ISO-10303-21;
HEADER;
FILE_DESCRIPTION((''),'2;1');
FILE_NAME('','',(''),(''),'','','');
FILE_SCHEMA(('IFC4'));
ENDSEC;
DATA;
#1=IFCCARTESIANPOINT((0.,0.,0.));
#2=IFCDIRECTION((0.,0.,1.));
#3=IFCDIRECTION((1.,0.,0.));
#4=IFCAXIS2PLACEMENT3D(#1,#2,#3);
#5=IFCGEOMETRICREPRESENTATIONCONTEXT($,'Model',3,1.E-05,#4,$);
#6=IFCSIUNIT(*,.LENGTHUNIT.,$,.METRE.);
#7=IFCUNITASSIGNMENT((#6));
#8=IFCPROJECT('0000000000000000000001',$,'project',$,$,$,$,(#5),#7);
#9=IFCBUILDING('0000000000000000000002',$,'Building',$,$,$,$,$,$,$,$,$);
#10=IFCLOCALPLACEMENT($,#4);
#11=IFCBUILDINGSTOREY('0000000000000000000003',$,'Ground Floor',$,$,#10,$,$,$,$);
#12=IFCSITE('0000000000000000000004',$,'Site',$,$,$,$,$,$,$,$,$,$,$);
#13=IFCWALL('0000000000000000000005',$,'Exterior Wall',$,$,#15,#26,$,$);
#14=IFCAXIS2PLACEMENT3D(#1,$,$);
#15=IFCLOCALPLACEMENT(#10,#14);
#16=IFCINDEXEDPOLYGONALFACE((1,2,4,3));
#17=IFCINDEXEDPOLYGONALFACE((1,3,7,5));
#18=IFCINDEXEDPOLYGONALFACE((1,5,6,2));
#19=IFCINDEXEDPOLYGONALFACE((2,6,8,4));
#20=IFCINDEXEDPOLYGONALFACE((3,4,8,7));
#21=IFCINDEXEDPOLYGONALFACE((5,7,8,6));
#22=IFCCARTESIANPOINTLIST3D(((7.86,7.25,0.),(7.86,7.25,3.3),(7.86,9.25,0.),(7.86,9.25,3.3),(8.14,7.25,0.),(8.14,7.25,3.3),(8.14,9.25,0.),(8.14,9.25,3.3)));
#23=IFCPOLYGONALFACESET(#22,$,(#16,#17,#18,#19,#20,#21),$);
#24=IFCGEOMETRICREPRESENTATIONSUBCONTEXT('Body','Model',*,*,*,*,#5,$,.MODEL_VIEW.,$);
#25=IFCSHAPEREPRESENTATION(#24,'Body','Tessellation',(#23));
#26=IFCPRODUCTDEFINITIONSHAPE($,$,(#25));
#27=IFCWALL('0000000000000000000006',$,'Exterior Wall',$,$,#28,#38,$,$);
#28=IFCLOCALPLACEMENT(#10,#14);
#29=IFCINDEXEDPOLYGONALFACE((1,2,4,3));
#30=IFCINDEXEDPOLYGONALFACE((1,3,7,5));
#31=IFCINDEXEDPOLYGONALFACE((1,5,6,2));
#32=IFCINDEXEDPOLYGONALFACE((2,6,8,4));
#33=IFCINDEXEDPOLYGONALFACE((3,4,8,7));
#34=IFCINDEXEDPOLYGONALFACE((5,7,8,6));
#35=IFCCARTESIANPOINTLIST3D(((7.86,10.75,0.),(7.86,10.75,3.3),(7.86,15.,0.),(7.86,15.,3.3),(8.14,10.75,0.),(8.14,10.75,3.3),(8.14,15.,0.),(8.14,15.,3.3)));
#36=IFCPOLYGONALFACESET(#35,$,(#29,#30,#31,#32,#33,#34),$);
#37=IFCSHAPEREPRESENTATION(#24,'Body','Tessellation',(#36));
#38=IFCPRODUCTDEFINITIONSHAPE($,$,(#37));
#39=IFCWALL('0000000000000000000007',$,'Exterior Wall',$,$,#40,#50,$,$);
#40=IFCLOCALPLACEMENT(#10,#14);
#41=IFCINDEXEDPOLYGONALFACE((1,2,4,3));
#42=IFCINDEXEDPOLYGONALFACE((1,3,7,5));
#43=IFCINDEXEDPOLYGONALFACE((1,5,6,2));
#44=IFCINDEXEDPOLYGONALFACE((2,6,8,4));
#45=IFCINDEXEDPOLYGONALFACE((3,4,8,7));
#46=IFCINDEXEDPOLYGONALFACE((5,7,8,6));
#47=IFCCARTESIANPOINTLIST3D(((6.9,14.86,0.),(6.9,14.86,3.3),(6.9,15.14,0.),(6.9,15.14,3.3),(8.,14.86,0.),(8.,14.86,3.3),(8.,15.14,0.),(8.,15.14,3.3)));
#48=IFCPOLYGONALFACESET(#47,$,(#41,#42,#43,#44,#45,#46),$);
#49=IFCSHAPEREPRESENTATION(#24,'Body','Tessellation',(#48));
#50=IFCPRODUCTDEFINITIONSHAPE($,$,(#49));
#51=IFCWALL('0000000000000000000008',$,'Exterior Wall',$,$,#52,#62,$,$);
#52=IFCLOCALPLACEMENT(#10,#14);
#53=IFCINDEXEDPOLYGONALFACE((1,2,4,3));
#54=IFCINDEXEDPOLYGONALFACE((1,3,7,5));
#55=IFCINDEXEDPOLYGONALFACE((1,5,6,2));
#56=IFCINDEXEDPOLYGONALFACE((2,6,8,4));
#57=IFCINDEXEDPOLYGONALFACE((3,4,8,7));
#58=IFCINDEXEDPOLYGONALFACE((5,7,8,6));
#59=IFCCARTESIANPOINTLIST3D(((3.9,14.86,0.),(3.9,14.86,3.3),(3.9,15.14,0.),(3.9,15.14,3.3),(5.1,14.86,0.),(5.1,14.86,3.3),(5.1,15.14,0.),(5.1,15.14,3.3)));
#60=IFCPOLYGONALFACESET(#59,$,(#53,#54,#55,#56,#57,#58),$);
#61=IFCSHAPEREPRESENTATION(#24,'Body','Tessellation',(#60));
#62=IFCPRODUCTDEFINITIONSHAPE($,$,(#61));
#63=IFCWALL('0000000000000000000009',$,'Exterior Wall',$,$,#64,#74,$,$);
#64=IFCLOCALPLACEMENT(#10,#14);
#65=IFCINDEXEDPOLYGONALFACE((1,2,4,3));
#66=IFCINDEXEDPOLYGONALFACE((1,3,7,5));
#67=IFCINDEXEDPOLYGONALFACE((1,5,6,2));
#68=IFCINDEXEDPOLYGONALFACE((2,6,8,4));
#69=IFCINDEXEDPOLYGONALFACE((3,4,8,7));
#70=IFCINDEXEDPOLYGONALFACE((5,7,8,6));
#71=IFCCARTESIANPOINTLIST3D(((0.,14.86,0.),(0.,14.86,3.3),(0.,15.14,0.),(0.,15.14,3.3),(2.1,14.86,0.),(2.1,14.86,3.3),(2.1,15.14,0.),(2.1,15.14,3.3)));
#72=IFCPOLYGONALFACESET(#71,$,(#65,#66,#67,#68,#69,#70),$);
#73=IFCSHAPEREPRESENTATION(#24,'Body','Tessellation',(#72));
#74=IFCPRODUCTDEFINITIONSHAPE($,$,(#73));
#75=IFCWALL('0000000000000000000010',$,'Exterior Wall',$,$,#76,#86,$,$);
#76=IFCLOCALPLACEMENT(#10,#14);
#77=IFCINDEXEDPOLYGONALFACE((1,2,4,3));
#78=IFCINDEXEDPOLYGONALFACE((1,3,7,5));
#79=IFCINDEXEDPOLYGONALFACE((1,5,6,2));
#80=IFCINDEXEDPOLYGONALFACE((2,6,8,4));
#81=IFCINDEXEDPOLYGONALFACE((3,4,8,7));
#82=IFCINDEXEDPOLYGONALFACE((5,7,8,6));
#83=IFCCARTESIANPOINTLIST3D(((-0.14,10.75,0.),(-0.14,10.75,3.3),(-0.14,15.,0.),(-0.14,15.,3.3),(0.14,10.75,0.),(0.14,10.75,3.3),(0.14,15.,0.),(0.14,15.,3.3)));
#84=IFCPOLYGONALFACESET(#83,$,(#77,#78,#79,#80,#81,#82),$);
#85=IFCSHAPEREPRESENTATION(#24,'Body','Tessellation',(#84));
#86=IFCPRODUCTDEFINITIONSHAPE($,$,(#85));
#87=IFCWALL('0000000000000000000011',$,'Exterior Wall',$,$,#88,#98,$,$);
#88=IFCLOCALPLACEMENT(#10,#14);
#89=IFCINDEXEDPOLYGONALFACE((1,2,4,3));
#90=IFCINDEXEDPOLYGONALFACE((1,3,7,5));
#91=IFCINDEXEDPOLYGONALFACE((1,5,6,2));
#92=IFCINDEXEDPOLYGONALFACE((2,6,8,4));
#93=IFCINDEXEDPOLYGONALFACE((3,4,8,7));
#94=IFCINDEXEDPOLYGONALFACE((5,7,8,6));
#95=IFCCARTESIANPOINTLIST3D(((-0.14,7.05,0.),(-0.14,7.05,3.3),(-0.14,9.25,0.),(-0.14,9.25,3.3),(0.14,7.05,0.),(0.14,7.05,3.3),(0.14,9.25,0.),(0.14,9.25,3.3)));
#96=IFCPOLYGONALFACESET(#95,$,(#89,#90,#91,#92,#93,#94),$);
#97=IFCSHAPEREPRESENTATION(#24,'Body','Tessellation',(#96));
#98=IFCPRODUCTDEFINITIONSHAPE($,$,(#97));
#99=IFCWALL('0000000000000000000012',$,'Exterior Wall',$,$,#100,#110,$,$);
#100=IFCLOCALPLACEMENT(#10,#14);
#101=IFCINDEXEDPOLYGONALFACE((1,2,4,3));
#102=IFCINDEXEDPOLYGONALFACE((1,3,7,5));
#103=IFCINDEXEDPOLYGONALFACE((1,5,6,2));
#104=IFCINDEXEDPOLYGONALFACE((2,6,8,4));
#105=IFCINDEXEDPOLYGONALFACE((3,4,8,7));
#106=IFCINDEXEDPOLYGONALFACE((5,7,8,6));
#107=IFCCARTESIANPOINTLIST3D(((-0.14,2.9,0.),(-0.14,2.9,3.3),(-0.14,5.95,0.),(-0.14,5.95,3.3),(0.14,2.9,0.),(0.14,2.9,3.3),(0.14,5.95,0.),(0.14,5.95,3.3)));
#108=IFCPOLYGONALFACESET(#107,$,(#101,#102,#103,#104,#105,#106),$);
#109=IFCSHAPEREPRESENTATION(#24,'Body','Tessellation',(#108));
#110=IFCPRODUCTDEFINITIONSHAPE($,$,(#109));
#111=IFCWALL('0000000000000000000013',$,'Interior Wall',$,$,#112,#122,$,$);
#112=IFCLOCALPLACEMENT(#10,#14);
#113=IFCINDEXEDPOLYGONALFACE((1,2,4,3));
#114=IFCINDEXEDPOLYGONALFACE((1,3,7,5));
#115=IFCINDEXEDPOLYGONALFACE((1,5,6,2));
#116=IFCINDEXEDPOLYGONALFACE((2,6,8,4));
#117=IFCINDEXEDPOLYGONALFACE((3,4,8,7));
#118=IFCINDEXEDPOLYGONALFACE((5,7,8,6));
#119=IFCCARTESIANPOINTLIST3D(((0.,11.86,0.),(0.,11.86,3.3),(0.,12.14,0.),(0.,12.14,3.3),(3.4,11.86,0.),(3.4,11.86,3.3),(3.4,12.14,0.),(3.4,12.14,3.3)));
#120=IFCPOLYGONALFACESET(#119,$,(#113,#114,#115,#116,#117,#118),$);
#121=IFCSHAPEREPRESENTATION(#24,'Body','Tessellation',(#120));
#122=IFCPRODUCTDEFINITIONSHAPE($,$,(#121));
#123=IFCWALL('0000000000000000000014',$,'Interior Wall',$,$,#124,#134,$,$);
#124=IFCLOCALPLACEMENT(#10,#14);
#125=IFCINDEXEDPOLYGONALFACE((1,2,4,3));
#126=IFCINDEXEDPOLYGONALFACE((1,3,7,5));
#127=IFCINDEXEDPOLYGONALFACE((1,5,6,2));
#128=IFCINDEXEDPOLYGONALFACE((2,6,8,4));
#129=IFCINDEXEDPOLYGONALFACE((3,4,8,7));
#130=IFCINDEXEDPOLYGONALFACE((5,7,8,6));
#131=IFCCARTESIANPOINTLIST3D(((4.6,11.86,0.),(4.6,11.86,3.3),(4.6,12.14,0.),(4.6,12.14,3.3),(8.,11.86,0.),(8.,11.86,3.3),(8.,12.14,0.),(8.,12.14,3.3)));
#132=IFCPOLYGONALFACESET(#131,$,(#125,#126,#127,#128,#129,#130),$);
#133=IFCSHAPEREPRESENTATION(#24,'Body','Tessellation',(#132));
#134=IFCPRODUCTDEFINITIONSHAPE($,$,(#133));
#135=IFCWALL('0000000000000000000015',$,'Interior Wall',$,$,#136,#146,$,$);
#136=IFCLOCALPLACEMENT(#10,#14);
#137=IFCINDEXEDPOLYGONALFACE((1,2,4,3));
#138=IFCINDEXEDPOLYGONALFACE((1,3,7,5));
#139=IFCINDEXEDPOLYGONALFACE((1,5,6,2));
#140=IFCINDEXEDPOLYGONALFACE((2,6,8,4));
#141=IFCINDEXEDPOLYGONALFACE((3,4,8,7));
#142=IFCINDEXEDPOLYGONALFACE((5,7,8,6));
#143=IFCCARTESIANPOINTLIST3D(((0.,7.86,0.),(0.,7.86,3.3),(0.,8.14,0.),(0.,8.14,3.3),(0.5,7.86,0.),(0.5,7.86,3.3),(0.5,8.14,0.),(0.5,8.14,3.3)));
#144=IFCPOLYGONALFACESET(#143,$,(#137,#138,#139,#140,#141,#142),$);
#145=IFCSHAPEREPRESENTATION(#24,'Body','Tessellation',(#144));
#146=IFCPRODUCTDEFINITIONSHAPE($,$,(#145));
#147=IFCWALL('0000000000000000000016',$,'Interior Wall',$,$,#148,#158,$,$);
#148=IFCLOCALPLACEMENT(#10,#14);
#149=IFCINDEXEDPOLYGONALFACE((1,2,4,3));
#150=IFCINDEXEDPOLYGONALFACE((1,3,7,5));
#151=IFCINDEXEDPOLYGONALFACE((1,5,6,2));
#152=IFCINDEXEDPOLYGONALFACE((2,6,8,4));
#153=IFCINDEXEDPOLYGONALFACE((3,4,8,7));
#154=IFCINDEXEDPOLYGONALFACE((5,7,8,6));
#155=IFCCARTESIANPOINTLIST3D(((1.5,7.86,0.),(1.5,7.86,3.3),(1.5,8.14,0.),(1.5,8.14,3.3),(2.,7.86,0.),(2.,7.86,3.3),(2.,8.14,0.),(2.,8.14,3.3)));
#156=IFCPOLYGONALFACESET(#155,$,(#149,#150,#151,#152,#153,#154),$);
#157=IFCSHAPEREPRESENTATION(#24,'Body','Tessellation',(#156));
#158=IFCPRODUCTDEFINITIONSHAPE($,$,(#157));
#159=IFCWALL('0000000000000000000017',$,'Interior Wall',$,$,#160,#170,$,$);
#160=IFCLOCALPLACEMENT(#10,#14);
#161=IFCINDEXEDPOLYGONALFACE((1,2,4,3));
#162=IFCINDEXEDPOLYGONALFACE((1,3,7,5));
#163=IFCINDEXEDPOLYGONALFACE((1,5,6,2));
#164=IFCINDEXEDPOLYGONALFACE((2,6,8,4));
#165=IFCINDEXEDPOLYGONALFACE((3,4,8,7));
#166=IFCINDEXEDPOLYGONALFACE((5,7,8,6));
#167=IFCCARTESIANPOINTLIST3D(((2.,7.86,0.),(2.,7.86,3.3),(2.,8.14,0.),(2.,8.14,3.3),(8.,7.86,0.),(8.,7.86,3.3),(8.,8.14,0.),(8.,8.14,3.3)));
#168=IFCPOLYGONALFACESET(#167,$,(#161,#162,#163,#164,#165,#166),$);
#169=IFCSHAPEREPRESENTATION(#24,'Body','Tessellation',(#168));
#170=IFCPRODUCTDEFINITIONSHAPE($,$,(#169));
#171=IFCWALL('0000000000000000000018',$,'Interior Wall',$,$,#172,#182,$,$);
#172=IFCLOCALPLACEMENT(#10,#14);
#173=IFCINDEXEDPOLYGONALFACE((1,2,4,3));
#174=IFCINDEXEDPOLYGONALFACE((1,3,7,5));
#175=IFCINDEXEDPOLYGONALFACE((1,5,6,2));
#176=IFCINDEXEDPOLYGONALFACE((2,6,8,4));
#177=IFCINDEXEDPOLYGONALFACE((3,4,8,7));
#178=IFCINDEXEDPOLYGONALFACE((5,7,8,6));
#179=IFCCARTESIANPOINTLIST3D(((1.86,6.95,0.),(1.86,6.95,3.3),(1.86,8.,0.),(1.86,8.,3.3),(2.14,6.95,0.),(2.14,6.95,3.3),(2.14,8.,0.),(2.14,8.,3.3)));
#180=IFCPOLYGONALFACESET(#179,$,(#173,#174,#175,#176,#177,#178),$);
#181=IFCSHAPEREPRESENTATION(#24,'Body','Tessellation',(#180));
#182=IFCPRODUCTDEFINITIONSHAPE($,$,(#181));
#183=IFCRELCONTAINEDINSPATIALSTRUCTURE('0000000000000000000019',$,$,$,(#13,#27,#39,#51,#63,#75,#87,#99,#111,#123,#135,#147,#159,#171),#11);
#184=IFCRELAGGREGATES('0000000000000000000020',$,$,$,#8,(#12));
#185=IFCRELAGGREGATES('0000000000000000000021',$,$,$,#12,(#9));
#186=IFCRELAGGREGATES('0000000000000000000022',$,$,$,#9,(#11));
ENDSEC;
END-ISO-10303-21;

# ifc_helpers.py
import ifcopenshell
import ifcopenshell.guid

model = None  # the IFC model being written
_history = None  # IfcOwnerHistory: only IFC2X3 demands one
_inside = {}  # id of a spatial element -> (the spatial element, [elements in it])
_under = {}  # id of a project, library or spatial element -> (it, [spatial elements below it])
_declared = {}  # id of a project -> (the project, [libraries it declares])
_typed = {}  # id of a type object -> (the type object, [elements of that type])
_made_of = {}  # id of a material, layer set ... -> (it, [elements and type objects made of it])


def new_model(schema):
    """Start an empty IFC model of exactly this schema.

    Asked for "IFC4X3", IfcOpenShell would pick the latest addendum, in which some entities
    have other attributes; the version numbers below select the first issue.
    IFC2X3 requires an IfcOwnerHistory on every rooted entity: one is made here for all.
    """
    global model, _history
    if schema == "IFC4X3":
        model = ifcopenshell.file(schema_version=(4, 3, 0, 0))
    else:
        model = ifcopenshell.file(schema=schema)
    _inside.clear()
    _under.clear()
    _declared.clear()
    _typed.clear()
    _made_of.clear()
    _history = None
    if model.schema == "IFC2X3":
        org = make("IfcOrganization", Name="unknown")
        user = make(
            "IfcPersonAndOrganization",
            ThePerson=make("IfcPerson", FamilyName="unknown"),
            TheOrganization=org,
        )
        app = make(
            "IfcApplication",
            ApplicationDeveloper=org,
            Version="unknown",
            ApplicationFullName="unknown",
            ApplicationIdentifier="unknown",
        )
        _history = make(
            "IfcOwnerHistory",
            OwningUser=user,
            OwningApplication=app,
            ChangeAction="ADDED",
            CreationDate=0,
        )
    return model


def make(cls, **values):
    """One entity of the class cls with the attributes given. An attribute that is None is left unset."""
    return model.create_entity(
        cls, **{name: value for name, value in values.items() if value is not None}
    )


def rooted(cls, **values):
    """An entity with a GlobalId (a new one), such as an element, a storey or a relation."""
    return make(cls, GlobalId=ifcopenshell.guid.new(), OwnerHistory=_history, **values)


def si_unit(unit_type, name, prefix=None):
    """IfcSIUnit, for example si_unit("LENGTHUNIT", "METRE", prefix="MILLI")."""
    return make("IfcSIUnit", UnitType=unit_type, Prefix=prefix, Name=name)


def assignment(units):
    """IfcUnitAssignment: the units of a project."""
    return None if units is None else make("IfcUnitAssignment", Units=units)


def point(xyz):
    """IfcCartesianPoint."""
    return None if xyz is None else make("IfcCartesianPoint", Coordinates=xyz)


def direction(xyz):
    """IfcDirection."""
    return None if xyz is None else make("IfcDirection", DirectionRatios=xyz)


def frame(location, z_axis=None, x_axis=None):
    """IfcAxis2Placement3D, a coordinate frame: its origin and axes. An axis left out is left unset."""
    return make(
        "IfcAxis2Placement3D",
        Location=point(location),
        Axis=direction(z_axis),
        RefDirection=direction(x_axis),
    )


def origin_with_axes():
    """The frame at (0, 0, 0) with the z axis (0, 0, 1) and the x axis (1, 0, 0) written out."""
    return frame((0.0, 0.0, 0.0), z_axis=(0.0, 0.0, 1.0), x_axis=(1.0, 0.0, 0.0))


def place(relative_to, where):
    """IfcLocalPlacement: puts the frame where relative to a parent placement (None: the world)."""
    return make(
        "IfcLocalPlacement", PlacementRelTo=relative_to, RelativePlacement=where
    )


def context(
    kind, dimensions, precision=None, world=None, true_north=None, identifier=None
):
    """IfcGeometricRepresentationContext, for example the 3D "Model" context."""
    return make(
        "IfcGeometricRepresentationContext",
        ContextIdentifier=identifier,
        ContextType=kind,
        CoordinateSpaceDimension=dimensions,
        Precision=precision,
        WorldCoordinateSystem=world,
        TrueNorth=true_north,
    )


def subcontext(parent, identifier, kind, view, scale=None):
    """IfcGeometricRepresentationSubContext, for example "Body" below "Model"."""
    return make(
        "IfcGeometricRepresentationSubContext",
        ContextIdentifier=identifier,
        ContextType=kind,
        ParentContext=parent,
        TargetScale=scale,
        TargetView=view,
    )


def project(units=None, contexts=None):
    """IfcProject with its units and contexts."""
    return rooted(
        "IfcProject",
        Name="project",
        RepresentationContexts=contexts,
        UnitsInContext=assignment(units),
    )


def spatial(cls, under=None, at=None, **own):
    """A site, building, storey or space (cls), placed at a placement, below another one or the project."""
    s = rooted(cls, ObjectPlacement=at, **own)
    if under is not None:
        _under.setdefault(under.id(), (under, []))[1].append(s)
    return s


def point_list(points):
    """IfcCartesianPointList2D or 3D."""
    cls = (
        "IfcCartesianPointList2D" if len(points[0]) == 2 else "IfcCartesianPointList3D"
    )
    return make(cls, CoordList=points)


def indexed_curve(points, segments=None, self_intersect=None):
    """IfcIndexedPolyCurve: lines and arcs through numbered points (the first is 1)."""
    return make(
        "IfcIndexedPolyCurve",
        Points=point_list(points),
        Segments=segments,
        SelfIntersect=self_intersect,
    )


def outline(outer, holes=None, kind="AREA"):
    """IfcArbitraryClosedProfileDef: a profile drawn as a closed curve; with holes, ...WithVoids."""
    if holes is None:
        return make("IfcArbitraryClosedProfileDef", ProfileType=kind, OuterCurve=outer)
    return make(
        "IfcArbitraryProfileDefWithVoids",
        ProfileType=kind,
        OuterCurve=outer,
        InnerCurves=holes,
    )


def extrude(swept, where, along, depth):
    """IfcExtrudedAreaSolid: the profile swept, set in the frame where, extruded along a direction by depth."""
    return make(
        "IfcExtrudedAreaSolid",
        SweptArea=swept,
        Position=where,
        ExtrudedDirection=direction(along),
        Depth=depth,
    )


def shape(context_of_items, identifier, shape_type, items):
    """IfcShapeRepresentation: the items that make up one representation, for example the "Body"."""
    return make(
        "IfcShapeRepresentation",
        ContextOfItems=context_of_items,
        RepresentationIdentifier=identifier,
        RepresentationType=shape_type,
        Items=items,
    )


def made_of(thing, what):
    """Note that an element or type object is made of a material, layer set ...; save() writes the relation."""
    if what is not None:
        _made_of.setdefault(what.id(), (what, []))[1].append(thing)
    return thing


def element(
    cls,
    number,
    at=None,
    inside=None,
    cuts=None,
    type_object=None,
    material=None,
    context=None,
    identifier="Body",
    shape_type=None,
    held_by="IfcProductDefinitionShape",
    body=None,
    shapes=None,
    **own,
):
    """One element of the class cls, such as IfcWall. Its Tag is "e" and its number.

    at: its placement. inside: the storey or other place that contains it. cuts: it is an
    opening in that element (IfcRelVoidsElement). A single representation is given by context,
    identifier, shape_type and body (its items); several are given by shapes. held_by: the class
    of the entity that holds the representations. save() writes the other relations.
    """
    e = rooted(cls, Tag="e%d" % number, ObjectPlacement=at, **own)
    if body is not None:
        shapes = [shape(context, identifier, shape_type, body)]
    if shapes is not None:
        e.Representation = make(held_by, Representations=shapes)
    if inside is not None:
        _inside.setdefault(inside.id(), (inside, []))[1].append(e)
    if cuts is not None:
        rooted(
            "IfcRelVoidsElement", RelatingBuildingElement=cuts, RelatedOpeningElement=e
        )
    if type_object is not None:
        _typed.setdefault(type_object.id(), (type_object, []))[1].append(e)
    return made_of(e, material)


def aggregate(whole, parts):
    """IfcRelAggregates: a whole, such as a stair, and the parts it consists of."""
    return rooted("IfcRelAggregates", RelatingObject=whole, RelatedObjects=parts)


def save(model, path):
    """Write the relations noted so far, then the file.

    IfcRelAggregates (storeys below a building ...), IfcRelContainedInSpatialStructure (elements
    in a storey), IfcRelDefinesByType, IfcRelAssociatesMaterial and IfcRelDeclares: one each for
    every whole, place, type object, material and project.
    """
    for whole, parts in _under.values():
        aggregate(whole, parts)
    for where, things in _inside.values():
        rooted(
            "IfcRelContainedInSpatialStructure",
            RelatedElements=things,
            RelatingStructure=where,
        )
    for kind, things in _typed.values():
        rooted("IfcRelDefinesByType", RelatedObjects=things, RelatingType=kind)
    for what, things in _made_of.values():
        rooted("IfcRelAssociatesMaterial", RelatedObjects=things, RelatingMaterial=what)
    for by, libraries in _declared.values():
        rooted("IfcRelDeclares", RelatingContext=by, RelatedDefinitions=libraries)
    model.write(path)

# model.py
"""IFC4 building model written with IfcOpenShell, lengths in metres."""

from ifc_helpers import new_model, si_unit, frame, origin_with_axes, place, context, subcontext, project, spatial, indexed_curve, outline, extrude, element, save


model = new_model("IFC4")

# Units and contexts
model_context = context("Model", 3, precision=1e-05, world=origin_with_axes())
body_context = subcontext(model_context, "Body", "Model", "MODEL_VIEW")
ifc_project = project(units=[si_unit("LENGTHUNIT", "METRE")], contexts=[model_context])

# Site, building, storey
site = spatial("IfcSite", under=ifc_project, Name="Site")
building = spatial("IfcBuilding", under=site, Name="Building")
storey_placement = place(None, origin_with_axes())
storey = spatial("IfcBuildingStorey", under=building, at=storey_placement, Name="Ground Floor")

# Walls
wall_1_placement = place(storey_placement, frame((8.0, 7.25, 0.0), z_axis=(0.0, 0.0, 1.0), x_axis=(0.0, 1.0, 0.0)))
element("IfcWall", 1, at=wall_1_placement, inside=storey, Name="Exterior Wall", context=body_context, shape_type="SweptSolid", body=[
    extrude(outline(indexed_curve([(0.0, 0.0), (0.0, 0.28), (2.0, 0.28), (2.0, 0.0), (0.0, 0.0)], self_intersect=False)), frame((0.0, -0.14, 0.0), z_axis=(0.0, 0.0, 1.0), x_axis=(1.0, 0.0, 0.0)), (0.0, 0.0, 1.0), 3.3),
])
wall_2_placement = place(storey_placement, frame((8.0, 10.75, 0.0), z_axis=(0.0, 0.0, 1.0), x_axis=(0.0, 1.0, 0.0)))
element("IfcWall", 2, at=wall_2_placement, inside=storey, Name="Exterior Wall", context=body_context, shape_type="SweptSolid", body=[
    extrude(outline(indexed_curve([(0.0, 0.0), (0.0, 0.28), (4.25, 0.28), (4.25, 0.0), (0.0, 0.0)], self_intersect=False)), frame((0.0, -0.14, 0.0), z_axis=(0.0, 0.0, 1.0), x_axis=(1.0, 0.0, 0.0)), (0.0, 0.0, 1.0), 3.3),
])
wall_3_placement = place(storey_placement, frame((8.0, 15.0, 0.0), z_axis=(0.0, 0.0, 1.0), x_axis=(-1.0, 0.0, 0.0)))
element("IfcWall", 3, at=wall_3_placement, inside=storey, Name="Exterior Wall", context=body_context, shape_type="SweptSolid", body=[
    extrude(outline(indexed_curve([(0.0, 0.0), (0.0, 0.28), (1.1, 0.28), (1.1, 0.0), (0.0, 0.0)], self_intersect=False)), frame((0.0, -0.14, 0.0), z_axis=(0.0, 0.0, 1.0), x_axis=(1.0, 0.0, 0.0)), (0.0, 0.0, 1.0), 3.3),
])
wall_4_placement = place(storey_placement, frame((5.1, 15.0, 0.0), z_axis=(0.0, 0.0, 1.0), x_axis=(-1.0, 0.0, 0.0)))
element("IfcWall", 4, at=wall_4_placement, inside=storey, Name="Exterior Wall", context=body_context, shape_type="SweptSolid", body=[
    extrude(outline(indexed_curve([(0.0, 0.0), (0.0, 0.28), (1.2, 0.28), (1.2, 0.0), (0.0, 0.0)], self_intersect=False)), frame((0.0, -0.14, 0.0), z_axis=(0.0, 0.0, 1.0), x_axis=(1.0, 0.0, 0.0)), (0.0, 0.0, 1.0), 3.3),
])
wall_5_placement = place(storey_placement, frame((2.1, 15.0, 0.0), z_axis=(0.0, 0.0, 1.0), x_axis=(-1.0, 0.0, 0.0)))
element("IfcWall", 5, at=wall_5_placement, inside=storey, Name="Exterior Wall", context=body_context, shape_type="SweptSolid", body=[
    extrude(outline(indexed_curve([(0.0, 0.0), (0.0, 0.28), (2.1, 0.28), (2.1, 0.0), (0.0, 0.0)], self_intersect=False)), frame((0.0, -0.14, 0.0), z_axis=(0.0, 0.0, 1.0), x_axis=(1.0, 0.0, 0.0)), (0.0, 0.0, 1.0), 3.3),
])
wall_6_placement = place(storey_placement, frame((0.0, 15.0, 0.0), z_axis=(0.0, 0.0, 1.0), x_axis=(0.0, -1.0, 0.0)))
element("IfcWall", 6, at=wall_6_placement, inside=storey, Name="Exterior Wall", context=body_context, shape_type="SweptSolid", body=[
    extrude(outline(indexed_curve([(0.0, 0.0), (0.0, 0.28), (4.25, 0.28), (4.25, 0.0), (0.0, 0.0)], self_intersect=False)), frame((0.0, -0.14, 0.0), z_axis=(0.0, 0.0, 1.0), x_axis=(1.0, 0.0, 0.0)), (0.0, 0.0, 1.0), 3.3),
])
wall_7_placement = place(storey_placement, frame((0.0, 9.25, 0.0), z_axis=(0.0, 0.0, 1.0), x_axis=(0.0, -1.0, 0.0)))
element("IfcWall", 7, at=wall_7_placement, inside=storey, Name="Exterior Wall", context=body_context, shape_type="SweptSolid", body=[
    extrude(outline(indexed_curve([(0.0, 0.0), (0.0, 0.28), (2.2, 0.28), (2.2, 0.0), (0.0, 0.0)], self_intersect=False)), frame((0.0, -0.14, 0.0), z_axis=(0.0, 0.0, 1.0), x_axis=(1.0, 0.0, 0.0)), (0.0, 0.0, 1.0), 3.3),
])
wall_8_placement = place(storey_placement, frame((0.0, 5.95, 0.0), z_axis=(0.0, 0.0, 1.0), x_axis=(0.0, -1.0, 0.0)))
element("IfcWall", 8, at=wall_8_placement, inside=storey, Name="Exterior Wall", context=body_context, shape_type="SweptSolid", body=[
    extrude(outline(indexed_curve([(0.0, 0.0), (0.0, 0.28), (3.05, 0.28), (3.05, 0.0), (0.0, 0.0)], self_intersect=False)), frame((0.0, -0.14, 0.0), z_axis=(0.0, 0.0, 1.0), x_axis=(1.0, 0.0, 0.0)), (0.0, 0.0, 1.0), 3.3),
])
wall_9_placement = place(storey_placement, frame((0.0, 12.0, 0.0), z_axis=(0.0, 0.0, 1.0), x_axis=(1.0, 0.0, 0.0)))
element("IfcWall", 9, at=wall_9_placement, inside=storey, Name="Interior Wall", context=body_context, shape_type="SweptSolid", body=[
    extrude(outline(indexed_curve([(0.0, 0.0), (0.0, 0.28), (3.4, 0.28), (3.4, 0.0), (0.0, 0.0)], self_intersect=False)), frame((0.0, -0.14, 0.0), z_axis=(0.0, 0.0, 1.0), x_axis=(1.0, 0.0, 0.0)), (0.0, 0.0, 1.0), 3.3),
])
wall_10_placement = place(storey_placement, frame((4.6, 12.0, 0.0), z_axis=(0.0, 0.0, 1.0), x_axis=(1.0, 0.0, 0.0)))
element("IfcWall", 10, at=wall_10_placement, inside=storey, Name="Interior Wall", context=body_context, shape_type="SweptSolid", body=[
    extrude(outline(indexed_curve([(0.0, 0.0), (0.0, 0.28), (3.4, 0.28), (3.4, 0.0), (0.0, 0.0)], self_intersect=False)), frame((0.0, -0.14, 0.0), z_axis=(0.0, 0.0, 1.0), x_axis=(1.0, 0.0, 0.0)), (0.0, 0.0, 1.0), 3.3),
])
for number, where, z_axis, x_axis, name in (
    (11, (0.0, 8.0, 0.0), (0.0, 0.0, 1.0), (1.0, 0.0, 0.0), "Interior Wall"),
    (12, (1.5, 8.0, 0.0), (0.0, 0.0, 1.0), (1.0, 0.0, 0.0), "Interior Wall"),
):
    element("IfcWall", number, at=place(storey_placement, frame(where, z_axis=z_axis, x_axis=x_axis)), inside=storey, Name=name, context=body_context, shape_type="SweptSolid", body=[
        extrude(outline(indexed_curve([(0.0, 0.0), (0.0, 0.28), (0.5, 0.28), (0.5, 0.0), (0.0, 0.0)], self_intersect=False)), frame((0.0, -0.14, 0.0), z_axis=(0.0, 0.0, 1.0), x_axis=(1.0, 0.0, 0.0)), (0.0, 0.0, 1.0), 3.3),
    ])
wall_11_placement = place(storey_placement, frame((2.0, 8.0, 0.0), z_axis=(0.0, 0.0, 1.0), x_axis=(1.0, 0.0, 0.0)))
element("IfcWall", 13, at=wall_11_placement, inside=storey, Name="Interior Wall", context=body_context, shape_type="SweptSolid", body=[
    extrude(outline(indexed_curve([(0.0, 0.0), (0.0, 0.28), (6.0, 0.28), (6.0, 0.0), (0.0, 0.0)], self_intersect=False)), frame((0.0, -0.14, 0.0), z_axis=(0.0, 0.0, 1.0), x_axis=(1.0, 0.0, 0.0)), (0.0, 0.0, 1.0), 3.3),
])
wall_12_placement = place(storey_placement, frame((2.0, 6.95, 0.0), z_axis=(0.0, 0.0, 1.0), x_axis=(0.0, 1.0, 0.0)))
element("IfcWall", 14, at=wall_12_placement, inside=storey, Name="Interior Wall", context=body_context, shape_type="SweptSolid", body=[
    extrude(outline(indexed_curve([(0.0, 0.0), (0.0, 0.28), (1.05, 0.28), (1.05, 0.0), (0.0, 0.0)], self_intersect=False)), frame((0.0, -0.14, 0.0), z_axis=(0.0, 0.0, 1.0), x_axis=(1.0, 0.0, 0.0)), (0.0, 0.0, 1.0), 3.3),
])

save(model, "model.ifc")
